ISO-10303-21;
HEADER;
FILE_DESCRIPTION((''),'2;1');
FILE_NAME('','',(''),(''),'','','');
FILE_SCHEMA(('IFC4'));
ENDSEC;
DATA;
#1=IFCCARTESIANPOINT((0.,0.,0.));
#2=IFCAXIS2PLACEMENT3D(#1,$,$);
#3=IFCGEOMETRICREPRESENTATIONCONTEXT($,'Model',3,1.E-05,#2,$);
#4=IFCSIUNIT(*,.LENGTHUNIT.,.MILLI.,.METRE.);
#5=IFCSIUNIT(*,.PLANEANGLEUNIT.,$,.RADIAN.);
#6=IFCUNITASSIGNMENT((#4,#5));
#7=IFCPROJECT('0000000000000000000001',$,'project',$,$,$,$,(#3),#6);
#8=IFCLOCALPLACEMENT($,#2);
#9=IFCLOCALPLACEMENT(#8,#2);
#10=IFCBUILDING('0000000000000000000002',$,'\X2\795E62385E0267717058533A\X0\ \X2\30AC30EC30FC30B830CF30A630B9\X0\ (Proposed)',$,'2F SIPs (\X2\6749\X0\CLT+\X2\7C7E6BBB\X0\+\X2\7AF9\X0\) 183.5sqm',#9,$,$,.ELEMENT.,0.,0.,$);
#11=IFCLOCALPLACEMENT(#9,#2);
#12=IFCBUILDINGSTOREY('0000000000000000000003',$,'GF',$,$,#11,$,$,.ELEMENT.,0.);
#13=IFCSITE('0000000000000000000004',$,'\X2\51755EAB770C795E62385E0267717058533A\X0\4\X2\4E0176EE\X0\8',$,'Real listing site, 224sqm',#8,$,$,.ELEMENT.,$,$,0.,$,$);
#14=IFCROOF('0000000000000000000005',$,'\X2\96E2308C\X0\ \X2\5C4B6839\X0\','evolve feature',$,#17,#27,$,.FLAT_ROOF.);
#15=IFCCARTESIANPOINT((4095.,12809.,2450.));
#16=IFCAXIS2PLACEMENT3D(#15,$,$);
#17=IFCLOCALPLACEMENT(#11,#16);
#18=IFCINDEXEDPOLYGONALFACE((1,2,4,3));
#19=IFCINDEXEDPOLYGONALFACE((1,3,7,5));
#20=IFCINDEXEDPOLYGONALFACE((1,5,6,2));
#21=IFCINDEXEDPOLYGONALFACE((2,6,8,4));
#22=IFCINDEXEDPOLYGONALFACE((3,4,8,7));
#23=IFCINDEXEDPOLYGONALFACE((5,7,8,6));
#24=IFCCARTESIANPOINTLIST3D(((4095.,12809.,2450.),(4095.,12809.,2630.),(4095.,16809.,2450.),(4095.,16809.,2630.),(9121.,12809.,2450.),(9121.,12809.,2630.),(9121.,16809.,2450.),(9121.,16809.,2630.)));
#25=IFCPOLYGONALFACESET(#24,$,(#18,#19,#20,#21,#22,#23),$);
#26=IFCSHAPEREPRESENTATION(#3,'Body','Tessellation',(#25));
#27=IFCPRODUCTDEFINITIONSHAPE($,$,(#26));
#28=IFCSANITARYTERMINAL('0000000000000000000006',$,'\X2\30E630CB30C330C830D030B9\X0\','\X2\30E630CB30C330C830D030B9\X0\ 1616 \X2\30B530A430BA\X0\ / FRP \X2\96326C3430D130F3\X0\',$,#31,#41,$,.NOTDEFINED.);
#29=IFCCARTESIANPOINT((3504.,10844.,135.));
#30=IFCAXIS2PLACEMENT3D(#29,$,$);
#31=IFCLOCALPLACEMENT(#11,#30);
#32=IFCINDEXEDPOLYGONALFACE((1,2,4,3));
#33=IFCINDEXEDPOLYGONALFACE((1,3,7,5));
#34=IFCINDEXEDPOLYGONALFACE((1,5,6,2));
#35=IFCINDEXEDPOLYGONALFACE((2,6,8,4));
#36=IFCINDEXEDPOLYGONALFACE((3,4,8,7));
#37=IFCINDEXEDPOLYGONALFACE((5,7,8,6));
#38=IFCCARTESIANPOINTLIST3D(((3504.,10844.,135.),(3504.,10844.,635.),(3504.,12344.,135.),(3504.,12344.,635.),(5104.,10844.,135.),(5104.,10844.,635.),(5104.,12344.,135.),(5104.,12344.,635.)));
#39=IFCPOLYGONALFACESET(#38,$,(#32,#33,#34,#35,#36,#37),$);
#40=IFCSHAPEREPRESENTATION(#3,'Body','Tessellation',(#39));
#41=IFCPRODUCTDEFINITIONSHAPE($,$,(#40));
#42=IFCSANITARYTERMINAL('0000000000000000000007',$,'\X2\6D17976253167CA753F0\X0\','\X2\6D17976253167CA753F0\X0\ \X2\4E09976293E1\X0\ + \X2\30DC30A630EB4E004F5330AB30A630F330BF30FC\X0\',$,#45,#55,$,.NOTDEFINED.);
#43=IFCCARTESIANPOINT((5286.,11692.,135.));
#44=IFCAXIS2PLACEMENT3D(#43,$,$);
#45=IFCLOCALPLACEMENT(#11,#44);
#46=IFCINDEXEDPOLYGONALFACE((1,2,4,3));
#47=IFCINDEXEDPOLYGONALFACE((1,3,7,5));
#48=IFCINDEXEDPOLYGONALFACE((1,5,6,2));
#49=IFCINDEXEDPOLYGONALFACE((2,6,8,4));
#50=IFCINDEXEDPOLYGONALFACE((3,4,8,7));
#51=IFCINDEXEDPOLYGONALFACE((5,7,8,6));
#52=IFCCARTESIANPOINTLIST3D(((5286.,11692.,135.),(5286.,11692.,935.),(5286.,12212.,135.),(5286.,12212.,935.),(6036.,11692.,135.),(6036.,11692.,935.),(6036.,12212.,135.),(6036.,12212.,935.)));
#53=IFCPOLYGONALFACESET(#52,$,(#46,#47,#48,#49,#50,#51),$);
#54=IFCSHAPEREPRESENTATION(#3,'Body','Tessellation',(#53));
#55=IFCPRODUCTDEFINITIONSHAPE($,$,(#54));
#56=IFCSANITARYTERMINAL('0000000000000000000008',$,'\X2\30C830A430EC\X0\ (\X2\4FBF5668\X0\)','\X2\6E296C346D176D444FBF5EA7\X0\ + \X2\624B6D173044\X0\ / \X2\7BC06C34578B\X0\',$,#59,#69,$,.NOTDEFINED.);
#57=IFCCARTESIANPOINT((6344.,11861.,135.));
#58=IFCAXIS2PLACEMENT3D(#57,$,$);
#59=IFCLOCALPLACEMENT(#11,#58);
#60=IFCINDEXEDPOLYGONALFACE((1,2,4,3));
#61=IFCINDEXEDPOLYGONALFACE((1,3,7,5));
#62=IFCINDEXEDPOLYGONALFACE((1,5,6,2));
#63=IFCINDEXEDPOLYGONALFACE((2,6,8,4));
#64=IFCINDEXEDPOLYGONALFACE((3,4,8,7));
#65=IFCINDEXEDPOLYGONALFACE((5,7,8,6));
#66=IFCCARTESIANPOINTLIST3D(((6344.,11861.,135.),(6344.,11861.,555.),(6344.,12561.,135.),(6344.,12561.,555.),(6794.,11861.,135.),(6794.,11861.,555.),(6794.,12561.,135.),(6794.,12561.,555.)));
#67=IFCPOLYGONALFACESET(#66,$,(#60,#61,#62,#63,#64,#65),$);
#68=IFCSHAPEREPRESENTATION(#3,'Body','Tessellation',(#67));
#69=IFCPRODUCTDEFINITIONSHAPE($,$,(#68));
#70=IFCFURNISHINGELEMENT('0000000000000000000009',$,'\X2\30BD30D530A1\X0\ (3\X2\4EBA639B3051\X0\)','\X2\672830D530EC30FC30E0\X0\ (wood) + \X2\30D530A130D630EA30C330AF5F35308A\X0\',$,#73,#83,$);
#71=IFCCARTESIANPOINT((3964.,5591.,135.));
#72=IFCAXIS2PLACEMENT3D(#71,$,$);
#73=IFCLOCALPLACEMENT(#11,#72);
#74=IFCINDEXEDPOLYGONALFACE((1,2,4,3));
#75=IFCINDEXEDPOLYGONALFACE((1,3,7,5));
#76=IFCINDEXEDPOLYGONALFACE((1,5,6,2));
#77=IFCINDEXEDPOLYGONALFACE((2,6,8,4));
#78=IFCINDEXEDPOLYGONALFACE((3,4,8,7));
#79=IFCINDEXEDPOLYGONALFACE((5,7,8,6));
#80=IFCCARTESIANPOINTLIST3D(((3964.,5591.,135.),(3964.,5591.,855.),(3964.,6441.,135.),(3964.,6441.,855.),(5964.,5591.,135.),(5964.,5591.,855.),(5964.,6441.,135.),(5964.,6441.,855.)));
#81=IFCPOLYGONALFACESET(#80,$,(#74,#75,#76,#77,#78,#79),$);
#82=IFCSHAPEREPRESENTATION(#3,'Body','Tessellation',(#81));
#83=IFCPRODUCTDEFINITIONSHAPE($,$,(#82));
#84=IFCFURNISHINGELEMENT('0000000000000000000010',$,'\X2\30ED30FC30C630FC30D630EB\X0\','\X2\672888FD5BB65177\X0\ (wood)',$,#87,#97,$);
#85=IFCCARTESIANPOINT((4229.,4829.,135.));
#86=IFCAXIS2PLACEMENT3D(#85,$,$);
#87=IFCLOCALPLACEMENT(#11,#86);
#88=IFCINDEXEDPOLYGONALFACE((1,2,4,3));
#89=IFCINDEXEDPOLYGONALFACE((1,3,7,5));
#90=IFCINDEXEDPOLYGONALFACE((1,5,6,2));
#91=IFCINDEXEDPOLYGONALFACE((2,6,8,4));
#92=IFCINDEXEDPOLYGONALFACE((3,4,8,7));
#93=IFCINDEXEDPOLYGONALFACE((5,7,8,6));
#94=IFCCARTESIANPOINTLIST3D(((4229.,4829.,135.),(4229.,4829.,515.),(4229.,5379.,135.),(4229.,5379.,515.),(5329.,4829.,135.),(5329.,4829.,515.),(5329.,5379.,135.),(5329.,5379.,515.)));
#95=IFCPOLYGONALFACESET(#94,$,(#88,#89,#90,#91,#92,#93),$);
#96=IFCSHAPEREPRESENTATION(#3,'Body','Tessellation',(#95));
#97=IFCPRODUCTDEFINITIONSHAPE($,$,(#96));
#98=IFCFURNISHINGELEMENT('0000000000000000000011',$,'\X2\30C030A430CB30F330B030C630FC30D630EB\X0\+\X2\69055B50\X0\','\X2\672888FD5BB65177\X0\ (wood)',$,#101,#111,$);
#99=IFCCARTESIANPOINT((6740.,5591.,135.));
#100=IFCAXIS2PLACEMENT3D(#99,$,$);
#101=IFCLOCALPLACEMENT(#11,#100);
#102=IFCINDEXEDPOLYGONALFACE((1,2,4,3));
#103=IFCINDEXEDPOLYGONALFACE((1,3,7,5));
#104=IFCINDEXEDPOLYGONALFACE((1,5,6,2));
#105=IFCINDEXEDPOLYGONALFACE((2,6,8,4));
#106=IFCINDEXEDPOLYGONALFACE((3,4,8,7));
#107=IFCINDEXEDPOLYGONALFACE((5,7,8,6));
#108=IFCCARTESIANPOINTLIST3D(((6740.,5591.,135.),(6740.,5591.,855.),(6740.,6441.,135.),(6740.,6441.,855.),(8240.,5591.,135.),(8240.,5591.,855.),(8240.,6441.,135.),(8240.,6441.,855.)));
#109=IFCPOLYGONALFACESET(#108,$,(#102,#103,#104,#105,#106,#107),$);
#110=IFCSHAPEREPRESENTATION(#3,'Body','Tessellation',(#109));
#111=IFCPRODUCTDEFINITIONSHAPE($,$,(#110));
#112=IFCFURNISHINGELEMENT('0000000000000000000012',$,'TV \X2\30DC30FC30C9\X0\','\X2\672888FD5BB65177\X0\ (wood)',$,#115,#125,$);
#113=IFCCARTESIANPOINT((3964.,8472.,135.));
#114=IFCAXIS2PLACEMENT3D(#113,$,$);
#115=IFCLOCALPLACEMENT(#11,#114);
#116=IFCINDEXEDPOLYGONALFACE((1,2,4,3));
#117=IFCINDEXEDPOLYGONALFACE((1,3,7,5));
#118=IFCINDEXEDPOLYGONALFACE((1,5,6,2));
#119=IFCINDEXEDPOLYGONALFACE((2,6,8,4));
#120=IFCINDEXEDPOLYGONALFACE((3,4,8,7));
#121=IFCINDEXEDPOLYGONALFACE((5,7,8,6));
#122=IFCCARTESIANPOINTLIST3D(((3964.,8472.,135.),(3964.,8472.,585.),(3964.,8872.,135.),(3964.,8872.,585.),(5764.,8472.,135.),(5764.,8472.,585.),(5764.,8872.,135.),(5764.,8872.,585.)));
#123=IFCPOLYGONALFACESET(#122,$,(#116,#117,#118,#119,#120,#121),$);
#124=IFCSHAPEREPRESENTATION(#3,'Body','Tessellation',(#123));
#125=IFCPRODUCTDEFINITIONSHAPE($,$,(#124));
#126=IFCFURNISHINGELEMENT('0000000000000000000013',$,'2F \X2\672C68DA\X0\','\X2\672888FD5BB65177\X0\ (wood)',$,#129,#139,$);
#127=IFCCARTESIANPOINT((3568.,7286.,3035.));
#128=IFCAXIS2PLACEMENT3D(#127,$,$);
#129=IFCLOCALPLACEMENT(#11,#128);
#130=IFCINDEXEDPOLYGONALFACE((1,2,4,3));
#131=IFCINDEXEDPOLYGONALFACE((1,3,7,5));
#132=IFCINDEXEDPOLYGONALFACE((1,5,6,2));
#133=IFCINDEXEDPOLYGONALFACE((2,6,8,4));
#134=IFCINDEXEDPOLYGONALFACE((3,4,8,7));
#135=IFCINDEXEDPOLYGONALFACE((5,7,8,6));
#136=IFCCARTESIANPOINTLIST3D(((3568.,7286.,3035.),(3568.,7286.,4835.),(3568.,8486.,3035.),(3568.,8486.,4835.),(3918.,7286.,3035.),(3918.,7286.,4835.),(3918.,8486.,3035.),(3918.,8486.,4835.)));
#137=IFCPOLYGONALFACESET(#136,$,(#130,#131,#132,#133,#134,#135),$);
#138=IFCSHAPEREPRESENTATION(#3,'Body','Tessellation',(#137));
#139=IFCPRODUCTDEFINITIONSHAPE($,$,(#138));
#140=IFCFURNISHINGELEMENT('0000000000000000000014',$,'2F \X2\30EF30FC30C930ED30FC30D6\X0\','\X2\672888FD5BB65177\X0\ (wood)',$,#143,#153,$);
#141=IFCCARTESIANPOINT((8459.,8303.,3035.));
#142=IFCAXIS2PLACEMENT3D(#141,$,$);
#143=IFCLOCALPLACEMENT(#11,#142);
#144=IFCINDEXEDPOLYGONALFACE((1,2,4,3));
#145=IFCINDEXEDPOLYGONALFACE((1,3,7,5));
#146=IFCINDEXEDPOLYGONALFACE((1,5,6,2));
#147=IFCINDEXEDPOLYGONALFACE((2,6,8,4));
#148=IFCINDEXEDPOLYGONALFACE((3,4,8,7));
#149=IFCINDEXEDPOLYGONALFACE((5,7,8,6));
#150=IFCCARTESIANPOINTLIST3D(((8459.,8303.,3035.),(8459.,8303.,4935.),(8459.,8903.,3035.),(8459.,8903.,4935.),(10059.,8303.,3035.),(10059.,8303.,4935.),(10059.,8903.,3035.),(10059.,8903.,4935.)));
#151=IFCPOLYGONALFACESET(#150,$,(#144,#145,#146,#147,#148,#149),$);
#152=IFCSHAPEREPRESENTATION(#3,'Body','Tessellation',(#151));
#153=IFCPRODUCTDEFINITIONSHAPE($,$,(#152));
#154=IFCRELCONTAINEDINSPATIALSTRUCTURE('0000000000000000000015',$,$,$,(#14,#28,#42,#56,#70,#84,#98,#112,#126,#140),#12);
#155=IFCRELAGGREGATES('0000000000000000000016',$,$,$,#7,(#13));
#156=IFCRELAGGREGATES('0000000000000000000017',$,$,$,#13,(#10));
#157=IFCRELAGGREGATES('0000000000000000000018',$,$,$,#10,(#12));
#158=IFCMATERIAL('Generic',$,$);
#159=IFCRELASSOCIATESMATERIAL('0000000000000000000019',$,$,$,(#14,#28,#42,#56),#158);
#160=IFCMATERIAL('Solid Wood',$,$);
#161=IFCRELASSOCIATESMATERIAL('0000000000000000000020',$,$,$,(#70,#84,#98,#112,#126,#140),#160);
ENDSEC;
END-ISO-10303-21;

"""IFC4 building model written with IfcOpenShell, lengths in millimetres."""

from ifc_helpers import new_model, si_unit, frame, frame_2d, origin, place, context, project, spatial, rectangle, extrude, material, element, save


model = new_model("IFC4")

# Units and contexts
model_context = context("Model", 3, precision=1e-05, world=origin())
ifc_project = project(units=[si_unit("LENGTHUNIT", "METRE", prefix="MILLI"), si_unit("PLANEANGLEUNIT", "RADIAN")], contexts=[model_context])

# Site, building, storey
site_placement = place(None, origin())
site = spatial("IfcSite", under=ifc_project, at=site_placement, Name="兵庫県神戸市東灘区4丁目8", ObjectType="Real listing site, 224sqm", CompositionType="ELEMENT", RefElevation=0.0)
building_placement = place(site_placement, origin())
building = spatial("IfcBuilding", under=site, at=building_placement, Name="神戸市東灘区 ガレージハウス (Proposed)", ObjectType="2F SIPs (杉CLT+籾殻+竹) 183.5sqm", CompositionType="ELEMENT", ElevationOfRefHeight=0.0, ElevationOfTerrain=0.0)
storey_placement = place(building_placement, origin())
storey = spatial("IfcBuildingStorey", under=building, at=storey_placement, Name="GF", CompositionType="ELEMENT", Elevation=0.0)

# Shared definitions
ifc_material_1 = material(Name="Generic")

# Shared definitions
ifc_material_2 = material(Name="Solid Wood")

# Roof
roof_1_placement = place(storey_placement, frame((4095.0, 12809.0, 2450.0)))
element("IfcRoof", 1, at=roof_1_placement, inside=storey, material=ifc_material_1, Name="離れ 屋根", Description="evolve feature", PredefinedType="FLAT_ROOF", context=model_context, shape_type="SweptSolid", body=[
    extrude(rectangle(XDim=5026.0, YDim=4000.0, at=frame_2d((2513.0, 2000.0))), frame((4095.0, 12809.0, 2450.0)), (0.0, 0.0, 1.0), 180.0),
])

# Sanitary terminals
sanitary_terminal_1_placement = place(storey_placement, frame((3504.0, 10844.0, 135.0)))
element("IfcSanitaryTerminal", 2, at=sanitary_terminal_1_placement, inside=storey, material=ifc_material_1, Name="ユニットバス", Description="ユニットバス 1616 サイズ / FRP 防水パン", PredefinedType="NOTDEFINED", context=model_context, shape_type="SweptSolid", body=[
    extrude(rectangle(XDim=1600.0, YDim=1500.0, at=frame_2d((800.0, 750.0))), frame((3504.0, 10844.0, 135.0)), (0.0, 0.0, 1.0), 500.0),
])
sanitary_terminal_2_placement = place(storey_placement, frame((5286.0, 11692.0, 135.0)))
element("IfcSanitaryTerminal", 3, at=sanitary_terminal_2_placement, inside=storey, material=ifc_material_1, Name="洗面化粧台", Description="洗面化粧台 三面鏡 + ボウル一体カウンター", PredefinedType="NOTDEFINED", context=model_context, shape_type="SweptSolid", body=[
    extrude(rectangle(XDim=750.0, YDim=520.0, at=frame_2d((375.0, 260.0))), frame((5286.0, 11692.0, 135.0)), (0.0, 0.0, 1.0), 800.0),
])
sanitary_terminal_3_placement = place(storey_placement, frame((6344.0, 11861.0, 135.0)))
element("IfcSanitaryTerminal", 4, at=sanitary_terminal_3_placement, inside=storey, material=ifc_material_1, Name="トイレ (便器)", Description="温水洗浄便座 + 手洗い / 節水型", PredefinedType="NOTDEFINED", context=model_context, shape_type="SweptSolid", body=[
    extrude(rectangle(XDim=450.0, YDim=700.0, at=frame_2d((225.0, 350.0))), frame((6344.0, 11861.0, 135.0)), (0.0, 0.0, 1.0), 420.0),
])

# Furnishing elements
furnishing_1_placement = place(storey_placement, frame((3964.0, 5591.0, 135.0)))
element("IfcFurnishingElement", 5, at=furnishing_1_placement, inside=storey, material=ifc_material_2, Name="ソファ (3人掛け)", Description="木フレーム (wood) + ファブリック張り", context=model_context, shape_type="SweptSolid", body=[
    extrude(rectangle(XDim=2000.0, YDim=850.0, at=frame_2d((1000.0, 425.0))), frame((3964.0, 5591.0, 135.0)), (0.0, 0.0, 1.0), 720.0),
])
furnishing_2_placement = place(storey_placement, frame((4229.0, 4829.0, 135.0)))
element("IfcFurnishingElement", 6, at=furnishing_2_placement, inside=storey, material=ifc_material_2, Name="ローテーブル", Description="木製家具 (wood)", context=model_context, shape_type="SweptSolid", body=[
    extrude(rectangle(XDim=1100.0, YDim=550.0, at=frame_2d((550.0, 275.0))), frame((4229.0, 4829.0, 135.0)), (0.0, 0.0, 1.0), 380.0),
])
furnishing_3_placement = place(storey_placement, frame((6740.0, 5591.0, 135.0)))
element("IfcFurnishingElement", 7, at=furnishing_3_placement, inside=storey, material=ifc_material_2, Name="ダイニングテーブル+椅子", Description="木製家具 (wood)", context=model_context, shape_type="SweptSolid", body=[
    extrude(rectangle(XDim=1500.0, YDim=850.0, at=frame_2d((750.0, 425.0))), frame((6740.0, 5591.0, 135.0)), (0.0, 0.0, 1.0), 720.0),
])
furnishing_4_placement = place(storey_placement, frame((3964.0, 8472.0, 135.0)))
element("IfcFurnishingElement", 8, at=furnishing_4_placement, inside=storey, material=ifc_material_2, Name="TV ボード", Description="木製家具 (wood)", context=model_context, shape_type="SweptSolid", body=[
    extrude(rectangle(XDim=1800.0, YDim=400.0, at=frame_2d((900.0, 200.0))), frame((3964.0, 8472.0, 135.0)), (0.0, 0.0, 1.0), 450.0),
])
furnishing_5_placement = place(storey_placement, frame((3568.0, 7286.0, 3035.0)))
element("IfcFurnishingElement", 9, at=furnishing_5_placement, inside=storey, material=ifc_material_2, Name="2F 本棚", Description="木製家具 (wood)", context=model_context, shape_type="SweptSolid", body=[
    extrude(rectangle(XDim=350.0, YDim=1200.0, at=frame_2d((175.0, 600.0))), frame((3568.0, 7286.0, 3035.0)), (0.0, 0.0, 1.0), 1800.0),
])
furnishing_6_placement = place(storey_placement, frame((8459.0, 8303.0, 3035.0)))
element("IfcFurnishingElement", 10, at=furnishing_6_placement, inside=storey, material=ifc_material_2, Name="2F ワードローブ", Description="木製家具 (wood)", context=model_context, shape_type="SweptSolid", body=[
    extrude(rectangle(XDim=1600.0, YDim=600.0, at=frame_2d((800.0, 300.0))), frame((8459.0, 8303.0, 3035.0)), (0.0, 0.0, 1.0), 1900.0),
])

save(model, "model.ifc")
